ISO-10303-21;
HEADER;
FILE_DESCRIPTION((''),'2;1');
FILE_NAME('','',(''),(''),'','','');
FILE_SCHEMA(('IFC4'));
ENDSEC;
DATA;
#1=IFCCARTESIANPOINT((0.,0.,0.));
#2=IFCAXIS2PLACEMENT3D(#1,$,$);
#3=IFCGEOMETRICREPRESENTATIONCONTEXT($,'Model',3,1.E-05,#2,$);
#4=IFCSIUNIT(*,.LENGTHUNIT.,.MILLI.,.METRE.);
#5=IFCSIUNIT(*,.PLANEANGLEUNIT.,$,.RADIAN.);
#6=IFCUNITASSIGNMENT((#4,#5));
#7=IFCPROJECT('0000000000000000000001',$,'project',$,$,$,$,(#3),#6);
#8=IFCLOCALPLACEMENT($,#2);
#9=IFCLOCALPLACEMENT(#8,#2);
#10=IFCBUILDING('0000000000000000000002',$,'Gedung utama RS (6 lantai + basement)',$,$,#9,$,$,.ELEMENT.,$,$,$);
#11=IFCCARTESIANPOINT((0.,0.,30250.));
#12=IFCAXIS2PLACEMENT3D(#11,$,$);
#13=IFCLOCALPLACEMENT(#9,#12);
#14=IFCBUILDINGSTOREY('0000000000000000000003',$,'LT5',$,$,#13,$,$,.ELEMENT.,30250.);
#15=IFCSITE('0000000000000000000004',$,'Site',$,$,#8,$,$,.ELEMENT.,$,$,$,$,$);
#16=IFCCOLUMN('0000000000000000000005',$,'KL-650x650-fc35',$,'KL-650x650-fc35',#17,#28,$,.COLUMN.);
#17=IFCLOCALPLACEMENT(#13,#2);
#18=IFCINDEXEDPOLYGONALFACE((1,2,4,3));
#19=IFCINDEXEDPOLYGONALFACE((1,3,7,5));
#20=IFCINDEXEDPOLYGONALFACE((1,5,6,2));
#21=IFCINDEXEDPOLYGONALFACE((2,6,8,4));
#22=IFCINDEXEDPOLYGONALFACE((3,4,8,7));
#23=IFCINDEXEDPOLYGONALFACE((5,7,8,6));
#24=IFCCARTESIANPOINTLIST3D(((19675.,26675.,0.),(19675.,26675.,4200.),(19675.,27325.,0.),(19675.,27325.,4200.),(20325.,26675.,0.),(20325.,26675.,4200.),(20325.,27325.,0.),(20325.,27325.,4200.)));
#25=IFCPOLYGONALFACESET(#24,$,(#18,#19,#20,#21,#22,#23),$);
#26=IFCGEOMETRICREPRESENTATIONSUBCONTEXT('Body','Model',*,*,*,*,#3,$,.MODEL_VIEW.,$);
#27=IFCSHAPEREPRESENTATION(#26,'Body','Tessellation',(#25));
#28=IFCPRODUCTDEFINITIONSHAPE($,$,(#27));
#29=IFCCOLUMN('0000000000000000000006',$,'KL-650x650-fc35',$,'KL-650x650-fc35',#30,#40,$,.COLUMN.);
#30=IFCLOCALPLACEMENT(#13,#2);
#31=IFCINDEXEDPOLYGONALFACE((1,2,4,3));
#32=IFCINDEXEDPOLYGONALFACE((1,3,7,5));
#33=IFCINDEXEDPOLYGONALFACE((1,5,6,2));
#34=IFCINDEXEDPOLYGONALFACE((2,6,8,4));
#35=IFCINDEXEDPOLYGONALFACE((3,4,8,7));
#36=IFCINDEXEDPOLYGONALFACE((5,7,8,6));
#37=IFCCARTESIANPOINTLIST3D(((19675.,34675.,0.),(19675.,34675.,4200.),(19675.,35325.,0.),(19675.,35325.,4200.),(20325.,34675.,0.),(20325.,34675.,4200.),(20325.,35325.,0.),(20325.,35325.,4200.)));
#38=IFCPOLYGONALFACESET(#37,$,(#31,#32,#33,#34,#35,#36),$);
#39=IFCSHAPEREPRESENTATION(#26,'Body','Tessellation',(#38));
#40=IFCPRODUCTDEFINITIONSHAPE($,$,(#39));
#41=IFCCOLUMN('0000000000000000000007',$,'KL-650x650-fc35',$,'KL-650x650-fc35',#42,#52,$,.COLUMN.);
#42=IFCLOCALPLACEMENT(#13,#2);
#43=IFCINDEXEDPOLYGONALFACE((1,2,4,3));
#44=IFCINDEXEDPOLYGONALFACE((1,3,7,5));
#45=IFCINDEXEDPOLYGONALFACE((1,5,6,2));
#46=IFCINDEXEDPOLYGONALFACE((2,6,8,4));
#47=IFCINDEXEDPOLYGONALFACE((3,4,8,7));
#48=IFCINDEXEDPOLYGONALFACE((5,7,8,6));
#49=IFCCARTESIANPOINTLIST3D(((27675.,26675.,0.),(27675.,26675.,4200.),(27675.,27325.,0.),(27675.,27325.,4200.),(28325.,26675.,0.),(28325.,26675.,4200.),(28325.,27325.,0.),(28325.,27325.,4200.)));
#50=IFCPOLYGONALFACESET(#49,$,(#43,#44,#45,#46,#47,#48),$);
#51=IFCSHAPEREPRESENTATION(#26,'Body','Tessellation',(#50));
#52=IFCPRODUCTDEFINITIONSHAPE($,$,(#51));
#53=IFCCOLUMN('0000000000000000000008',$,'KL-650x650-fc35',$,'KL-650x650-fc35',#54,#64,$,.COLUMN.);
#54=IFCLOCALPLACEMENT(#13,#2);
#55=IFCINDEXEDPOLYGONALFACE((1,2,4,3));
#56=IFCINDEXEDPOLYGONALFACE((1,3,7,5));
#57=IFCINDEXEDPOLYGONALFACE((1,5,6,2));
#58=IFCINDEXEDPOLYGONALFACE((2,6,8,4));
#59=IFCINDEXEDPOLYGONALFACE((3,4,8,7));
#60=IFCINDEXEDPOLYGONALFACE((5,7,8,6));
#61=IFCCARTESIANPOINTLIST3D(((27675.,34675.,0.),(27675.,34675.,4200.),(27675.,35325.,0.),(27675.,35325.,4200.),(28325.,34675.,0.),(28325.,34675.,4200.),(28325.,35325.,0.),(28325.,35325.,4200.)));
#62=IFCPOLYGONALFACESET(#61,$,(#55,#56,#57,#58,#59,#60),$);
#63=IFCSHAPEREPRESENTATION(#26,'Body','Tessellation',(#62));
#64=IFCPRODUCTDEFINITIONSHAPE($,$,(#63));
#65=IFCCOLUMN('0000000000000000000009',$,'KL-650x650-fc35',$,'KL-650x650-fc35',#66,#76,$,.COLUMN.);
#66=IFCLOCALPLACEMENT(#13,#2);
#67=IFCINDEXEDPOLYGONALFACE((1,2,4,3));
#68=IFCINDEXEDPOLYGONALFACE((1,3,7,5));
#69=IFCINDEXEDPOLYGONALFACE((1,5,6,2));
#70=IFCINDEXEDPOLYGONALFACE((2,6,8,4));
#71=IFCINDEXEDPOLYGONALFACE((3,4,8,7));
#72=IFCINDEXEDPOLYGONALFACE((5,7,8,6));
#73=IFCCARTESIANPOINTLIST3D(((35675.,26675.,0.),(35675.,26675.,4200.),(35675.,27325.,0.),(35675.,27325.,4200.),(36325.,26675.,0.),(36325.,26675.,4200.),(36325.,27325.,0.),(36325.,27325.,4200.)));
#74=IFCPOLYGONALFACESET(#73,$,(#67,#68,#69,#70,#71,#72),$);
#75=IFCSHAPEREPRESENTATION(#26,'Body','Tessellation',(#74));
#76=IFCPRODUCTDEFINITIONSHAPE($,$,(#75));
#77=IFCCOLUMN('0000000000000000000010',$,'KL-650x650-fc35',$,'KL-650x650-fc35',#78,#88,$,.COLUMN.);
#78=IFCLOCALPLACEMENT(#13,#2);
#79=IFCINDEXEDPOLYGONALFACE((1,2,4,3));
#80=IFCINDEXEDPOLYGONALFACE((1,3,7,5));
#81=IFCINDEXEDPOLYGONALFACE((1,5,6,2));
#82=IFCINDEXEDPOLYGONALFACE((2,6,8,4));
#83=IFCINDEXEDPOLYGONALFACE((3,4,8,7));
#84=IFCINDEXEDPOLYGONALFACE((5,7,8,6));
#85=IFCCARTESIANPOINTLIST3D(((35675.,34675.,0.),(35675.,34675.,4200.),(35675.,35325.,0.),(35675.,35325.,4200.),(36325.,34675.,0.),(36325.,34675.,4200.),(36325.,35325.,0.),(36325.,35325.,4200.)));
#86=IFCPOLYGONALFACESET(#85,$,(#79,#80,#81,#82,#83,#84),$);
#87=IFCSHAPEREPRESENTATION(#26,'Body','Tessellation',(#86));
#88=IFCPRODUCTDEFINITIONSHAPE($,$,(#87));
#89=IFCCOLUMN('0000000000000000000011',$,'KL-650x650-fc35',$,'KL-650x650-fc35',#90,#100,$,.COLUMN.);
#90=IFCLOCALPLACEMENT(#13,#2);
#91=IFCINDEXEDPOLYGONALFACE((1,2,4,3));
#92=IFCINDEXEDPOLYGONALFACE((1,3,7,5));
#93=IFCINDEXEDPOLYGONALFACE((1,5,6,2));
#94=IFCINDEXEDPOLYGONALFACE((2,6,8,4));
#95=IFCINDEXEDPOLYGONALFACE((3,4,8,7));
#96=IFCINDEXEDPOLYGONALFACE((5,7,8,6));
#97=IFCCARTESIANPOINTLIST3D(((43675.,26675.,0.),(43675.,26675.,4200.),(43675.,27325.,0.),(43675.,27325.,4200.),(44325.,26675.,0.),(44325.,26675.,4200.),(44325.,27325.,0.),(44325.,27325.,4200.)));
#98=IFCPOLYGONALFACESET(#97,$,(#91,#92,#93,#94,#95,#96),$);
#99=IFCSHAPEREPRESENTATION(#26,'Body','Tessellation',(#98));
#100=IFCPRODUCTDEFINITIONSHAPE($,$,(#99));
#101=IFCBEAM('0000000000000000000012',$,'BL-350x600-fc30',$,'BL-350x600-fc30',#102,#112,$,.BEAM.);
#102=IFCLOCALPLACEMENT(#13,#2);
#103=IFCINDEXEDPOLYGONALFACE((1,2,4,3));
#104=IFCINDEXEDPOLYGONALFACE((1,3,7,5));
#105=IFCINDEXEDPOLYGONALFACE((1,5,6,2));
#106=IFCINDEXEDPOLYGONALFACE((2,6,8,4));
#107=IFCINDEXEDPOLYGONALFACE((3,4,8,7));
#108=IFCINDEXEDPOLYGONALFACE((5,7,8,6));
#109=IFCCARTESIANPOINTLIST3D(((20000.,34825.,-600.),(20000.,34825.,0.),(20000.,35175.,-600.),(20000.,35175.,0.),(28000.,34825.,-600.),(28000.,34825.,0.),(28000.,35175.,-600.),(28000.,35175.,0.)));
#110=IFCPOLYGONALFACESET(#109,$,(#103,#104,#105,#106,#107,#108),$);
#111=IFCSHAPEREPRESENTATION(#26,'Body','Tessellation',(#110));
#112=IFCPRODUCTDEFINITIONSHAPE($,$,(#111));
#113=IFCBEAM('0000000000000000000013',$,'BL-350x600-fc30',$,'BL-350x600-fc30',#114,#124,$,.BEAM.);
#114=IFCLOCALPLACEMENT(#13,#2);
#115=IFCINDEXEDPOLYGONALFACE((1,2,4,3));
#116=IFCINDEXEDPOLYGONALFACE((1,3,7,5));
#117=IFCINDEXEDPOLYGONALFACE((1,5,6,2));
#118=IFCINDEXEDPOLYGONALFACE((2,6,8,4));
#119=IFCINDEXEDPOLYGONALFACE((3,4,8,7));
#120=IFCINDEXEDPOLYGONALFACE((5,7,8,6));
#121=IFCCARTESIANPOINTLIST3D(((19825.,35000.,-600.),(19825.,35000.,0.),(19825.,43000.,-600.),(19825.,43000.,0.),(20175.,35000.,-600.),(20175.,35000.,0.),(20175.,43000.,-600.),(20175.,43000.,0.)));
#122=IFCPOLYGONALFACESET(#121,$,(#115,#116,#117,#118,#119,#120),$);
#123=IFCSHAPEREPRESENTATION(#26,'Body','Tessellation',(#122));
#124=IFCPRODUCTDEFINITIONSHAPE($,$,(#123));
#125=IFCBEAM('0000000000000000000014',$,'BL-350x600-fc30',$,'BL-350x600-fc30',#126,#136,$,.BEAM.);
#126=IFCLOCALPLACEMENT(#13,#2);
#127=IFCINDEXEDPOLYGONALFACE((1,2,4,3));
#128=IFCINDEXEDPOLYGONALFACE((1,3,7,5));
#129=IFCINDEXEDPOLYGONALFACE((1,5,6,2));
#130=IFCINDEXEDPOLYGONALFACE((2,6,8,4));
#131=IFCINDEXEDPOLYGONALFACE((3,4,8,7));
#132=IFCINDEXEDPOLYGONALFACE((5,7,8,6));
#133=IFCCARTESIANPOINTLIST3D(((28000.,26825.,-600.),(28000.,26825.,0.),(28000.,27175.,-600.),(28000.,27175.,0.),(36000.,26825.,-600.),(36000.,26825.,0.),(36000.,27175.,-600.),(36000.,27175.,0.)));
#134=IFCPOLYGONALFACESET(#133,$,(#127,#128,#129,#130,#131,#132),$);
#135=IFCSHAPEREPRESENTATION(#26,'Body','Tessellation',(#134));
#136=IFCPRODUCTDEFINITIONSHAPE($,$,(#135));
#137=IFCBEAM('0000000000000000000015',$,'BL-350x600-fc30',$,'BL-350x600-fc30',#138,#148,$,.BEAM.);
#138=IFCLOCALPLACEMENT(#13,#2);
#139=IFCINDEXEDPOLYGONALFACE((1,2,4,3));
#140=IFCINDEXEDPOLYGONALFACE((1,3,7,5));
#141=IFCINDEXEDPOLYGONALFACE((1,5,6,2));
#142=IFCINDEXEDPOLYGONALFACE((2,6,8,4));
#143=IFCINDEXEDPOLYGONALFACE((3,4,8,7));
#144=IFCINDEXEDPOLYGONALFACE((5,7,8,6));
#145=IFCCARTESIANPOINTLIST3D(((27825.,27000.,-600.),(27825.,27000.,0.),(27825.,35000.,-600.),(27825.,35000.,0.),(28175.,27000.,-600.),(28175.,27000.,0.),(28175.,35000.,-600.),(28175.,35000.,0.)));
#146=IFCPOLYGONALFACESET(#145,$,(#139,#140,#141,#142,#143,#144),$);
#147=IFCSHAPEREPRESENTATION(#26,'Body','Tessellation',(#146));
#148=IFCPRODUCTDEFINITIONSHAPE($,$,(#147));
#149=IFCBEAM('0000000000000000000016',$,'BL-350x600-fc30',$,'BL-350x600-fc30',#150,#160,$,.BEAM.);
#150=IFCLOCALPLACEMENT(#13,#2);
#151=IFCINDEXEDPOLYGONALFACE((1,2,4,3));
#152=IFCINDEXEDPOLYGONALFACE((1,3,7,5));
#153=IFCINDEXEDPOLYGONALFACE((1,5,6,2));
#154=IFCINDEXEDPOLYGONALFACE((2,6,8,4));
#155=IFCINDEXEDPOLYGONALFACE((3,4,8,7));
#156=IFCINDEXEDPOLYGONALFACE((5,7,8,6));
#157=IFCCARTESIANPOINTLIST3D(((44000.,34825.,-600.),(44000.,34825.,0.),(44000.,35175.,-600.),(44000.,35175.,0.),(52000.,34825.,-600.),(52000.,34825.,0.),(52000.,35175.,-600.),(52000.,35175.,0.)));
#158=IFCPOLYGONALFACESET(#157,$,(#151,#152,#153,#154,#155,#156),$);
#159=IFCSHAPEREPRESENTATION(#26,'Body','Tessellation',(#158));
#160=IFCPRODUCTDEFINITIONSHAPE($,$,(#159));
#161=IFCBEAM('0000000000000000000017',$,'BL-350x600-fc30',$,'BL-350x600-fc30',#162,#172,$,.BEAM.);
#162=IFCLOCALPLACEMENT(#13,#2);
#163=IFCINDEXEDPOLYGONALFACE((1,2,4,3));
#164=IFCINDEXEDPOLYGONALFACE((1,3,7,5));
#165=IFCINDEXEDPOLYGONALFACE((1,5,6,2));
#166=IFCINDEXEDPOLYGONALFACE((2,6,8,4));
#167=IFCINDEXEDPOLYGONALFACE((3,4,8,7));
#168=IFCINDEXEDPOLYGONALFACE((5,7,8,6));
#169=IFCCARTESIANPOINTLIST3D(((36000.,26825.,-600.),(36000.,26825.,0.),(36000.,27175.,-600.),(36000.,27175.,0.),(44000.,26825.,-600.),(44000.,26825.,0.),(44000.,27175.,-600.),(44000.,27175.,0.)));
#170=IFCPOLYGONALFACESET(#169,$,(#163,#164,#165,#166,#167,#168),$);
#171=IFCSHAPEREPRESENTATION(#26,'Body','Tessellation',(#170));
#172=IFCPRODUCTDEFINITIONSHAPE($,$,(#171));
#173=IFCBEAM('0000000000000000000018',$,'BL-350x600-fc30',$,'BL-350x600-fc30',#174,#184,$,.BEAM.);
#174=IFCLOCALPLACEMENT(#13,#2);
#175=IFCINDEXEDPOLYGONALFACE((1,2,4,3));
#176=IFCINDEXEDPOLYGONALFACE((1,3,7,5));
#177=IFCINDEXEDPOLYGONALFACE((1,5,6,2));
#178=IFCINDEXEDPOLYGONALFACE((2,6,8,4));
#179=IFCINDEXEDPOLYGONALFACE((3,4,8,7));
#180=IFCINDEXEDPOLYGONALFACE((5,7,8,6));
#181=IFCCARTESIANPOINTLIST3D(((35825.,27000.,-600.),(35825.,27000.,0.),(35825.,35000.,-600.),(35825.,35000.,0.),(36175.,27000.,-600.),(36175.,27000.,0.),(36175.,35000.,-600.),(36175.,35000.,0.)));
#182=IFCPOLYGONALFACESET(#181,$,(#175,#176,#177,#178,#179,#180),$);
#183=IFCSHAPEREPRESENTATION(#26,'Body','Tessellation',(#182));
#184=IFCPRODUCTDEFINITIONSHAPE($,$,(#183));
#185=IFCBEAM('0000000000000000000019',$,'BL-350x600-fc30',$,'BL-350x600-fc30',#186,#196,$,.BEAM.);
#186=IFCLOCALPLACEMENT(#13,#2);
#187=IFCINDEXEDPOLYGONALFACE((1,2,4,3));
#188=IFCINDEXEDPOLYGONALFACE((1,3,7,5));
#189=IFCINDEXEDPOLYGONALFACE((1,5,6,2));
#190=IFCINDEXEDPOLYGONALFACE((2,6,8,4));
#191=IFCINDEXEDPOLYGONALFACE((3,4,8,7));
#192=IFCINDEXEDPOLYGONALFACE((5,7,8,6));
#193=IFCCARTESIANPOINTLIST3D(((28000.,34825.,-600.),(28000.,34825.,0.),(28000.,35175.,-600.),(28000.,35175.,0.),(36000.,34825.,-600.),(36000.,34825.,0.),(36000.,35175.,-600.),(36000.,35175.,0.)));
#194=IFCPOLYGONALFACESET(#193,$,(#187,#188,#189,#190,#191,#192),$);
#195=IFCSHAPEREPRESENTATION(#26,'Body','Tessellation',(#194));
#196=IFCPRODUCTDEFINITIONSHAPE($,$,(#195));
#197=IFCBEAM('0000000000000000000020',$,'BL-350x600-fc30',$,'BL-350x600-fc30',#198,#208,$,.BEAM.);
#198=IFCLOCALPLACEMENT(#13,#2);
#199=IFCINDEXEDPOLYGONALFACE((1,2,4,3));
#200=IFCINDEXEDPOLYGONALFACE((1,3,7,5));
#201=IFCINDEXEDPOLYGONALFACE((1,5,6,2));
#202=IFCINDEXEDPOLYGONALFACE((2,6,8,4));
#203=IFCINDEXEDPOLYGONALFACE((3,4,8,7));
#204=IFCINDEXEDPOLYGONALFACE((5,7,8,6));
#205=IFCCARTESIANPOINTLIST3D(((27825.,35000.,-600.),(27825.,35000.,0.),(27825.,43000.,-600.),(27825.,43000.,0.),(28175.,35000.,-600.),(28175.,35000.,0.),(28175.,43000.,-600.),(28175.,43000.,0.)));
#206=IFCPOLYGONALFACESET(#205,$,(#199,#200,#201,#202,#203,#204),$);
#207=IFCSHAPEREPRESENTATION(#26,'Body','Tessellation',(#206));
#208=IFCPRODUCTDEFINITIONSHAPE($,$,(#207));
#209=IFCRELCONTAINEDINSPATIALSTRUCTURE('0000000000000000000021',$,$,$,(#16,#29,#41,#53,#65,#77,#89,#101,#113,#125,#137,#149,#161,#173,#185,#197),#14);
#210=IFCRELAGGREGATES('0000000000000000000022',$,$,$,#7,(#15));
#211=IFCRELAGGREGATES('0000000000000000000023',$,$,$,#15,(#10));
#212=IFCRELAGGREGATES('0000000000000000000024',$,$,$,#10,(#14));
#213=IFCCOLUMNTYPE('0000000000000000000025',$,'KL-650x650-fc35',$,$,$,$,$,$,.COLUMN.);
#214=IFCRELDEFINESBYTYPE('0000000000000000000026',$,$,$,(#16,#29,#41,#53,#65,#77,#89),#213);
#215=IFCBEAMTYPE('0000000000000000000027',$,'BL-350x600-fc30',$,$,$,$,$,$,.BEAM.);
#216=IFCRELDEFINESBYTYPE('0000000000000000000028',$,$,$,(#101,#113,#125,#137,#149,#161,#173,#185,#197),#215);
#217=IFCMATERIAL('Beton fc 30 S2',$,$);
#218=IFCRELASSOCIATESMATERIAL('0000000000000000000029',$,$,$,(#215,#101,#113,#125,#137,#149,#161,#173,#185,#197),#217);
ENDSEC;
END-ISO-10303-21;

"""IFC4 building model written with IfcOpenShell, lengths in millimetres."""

from ifc_helpers import new_model, si_unit, frame, origin, origin_2d, place, context, subcontext, project, spatial, rectangle, extrude, material, material_profile, profile_set, profile_usage, type_object, element, save


model = new_model("IFC4")

# Units and contexts
model_context = context("Model", 3, precision=1e-05, world=origin())
body_context = subcontext(model_context, "Body", "Model", "MODEL_VIEW")
ifc_project = project(units=[si_unit("LENGTHUNIT", "METRE", prefix="MILLI"), si_unit("PLANEANGLEUNIT", "RADIAN")], contexts=[model_context])

# Site, building, storey
site_placement = place(None, origin())
site = spatial("IfcSite", under=ifc_project, at=site_placement, Name="Site", CompositionType="ELEMENT")
building_placement = place(site_placement, origin())
building = spatial("IfcBuilding", under=site, at=building_placement, Name="Gedung utama RS (6 lantai + basement)", CompositionType="ELEMENT")
storey_placement = place(building_placement, frame((0.0, 0.0, 30250.0)))
storey = spatial("IfcBuildingStorey", under=building, at=storey_placement, Name="LT5", CompositionType="ELEMENT", Elevation=30250.0)

# Columns
ifc_material_profile_1 = material_profile(None, rectangle(XDim=650.0, YDim=650.0, at=origin_2d()), Name="KL-650x650-fc35")
ifc_profile_set_1 = profile_set([ifc_material_profile_1], Name="KL-650x650-fc35")
ifc_profile_usage_1 = profile_usage(ifc_profile_set_1, cardinal=5)
column_type = type_object("IfcColumnType", Name="KL-650x650-fc35", PredefinedType="COLUMN", material=ifc_profile_set_1)
for number, where, z_axis, x_axis, name in (
    (1, (20000.0, 27000.0, 0.0), (0.0, 0.0, 1.0), (1.0, 0.0, 0.0), "KL-650x650-fc35"),
    (2, (20000.0, 35000.0, 0.0), (0.0, 0.0, 1.0), (1.0, 0.0, 0.0), "KL-650x650-fc35"),
    (3, (28000.0, 27000.0, 0.0), (0.0, 0.0, 1.0), (1.0, 0.0, 0.0), "KL-650x650-fc35"),
    (4, (28000.0, 35000.0, 0.0), (0.0, 0.0, 1.0), (1.0, 0.0, 0.0), "KL-650x650-fc35"),
    (5, (36000.0, 27000.0, 0.0), (0.0, 0.0, 1.0), (1.0, 0.0, 0.0), "KL-650x650-fc35"),
    (6, (36000.0, 35000.0, 0.0), (0.0, 0.0, 1.0), (1.0, 0.0, 0.0), "KL-650x650-fc35"),
    (7, (44000.0, 27000.0, 0.0), (0.0, 0.0, 1.0), (1.0, 0.0, 0.0), "KL-650x650-fc35"),
):
    element("IfcColumn", number, at=place(storey_placement, frame(where, z_axis=z_axis, x_axis=x_axis)), inside=storey, type_object=column_type, material=ifc_profile_usage_1, Name=name, ObjectType="KL-650x650-fc35", PredefinedType="COLUMN", context=body_context, shape_type="SweptSolid", body=[
        extrude(rectangle(XDim=650.0, YDim=650.0, at=origin_2d()), origin(), (0.0, 0.0, 1.0), 4200.0),
    ])

# Beams
ifc_material = material(Name="Beton fc 30 S2")
ifc_material_profile_2 = material_profile(ifc_material, rectangle(XDim=350.0, YDim=600.0, at=origin_2d()), Name="BL-350x600-fc30")
ifc_profile_set_2 = profile_set([ifc_material_profile_2], Name="BL-350x600-fc30")
ifc_profile_usage_2 = profile_usage(ifc_profile_set_2, cardinal=8)
beam_type = type_object("IfcBeamType", Name="BL-350x600-fc30", PredefinedType="BEAM", material=ifc_profile_set_2)
beam_1_placement = place(storey_placement, frame((20000.0, 35000.0, -300.0)))
element("IfcBeam", 8, at=beam_1_placement, inside=storey, type_object=beam_type, material=ifc_profile_usage_2, Name="BL-350x600-fc30", ObjectType="BL-350x600-fc30", PredefinedType="BEAM", context=body_context, shape_type="SweptSolid", body=[
    extrude(rectangle(XDim=350.0, YDim=600.0, at=origin_2d()), frame((0.0, 0.0, 0.0), z_axis=(1.0, 0.0, 0.0), x_axis=(0.0, 1.0, 0.0)), (0.0, 0.0, 1.0), 8000.0),
])
beam_2_placement = place(storey_placement, frame((20000.0, 35000.0, -300.0)))
element("IfcBeam", 9, at=beam_2_placement, inside=storey, type_object=beam_type, material=ifc_profile_usage_2, Name="BL-350x600-fc30", ObjectType="BL-350x600-fc30", PredefinedType="BEAM", context=body_context, shape_type="SweptSolid", body=[
    extrude(rectangle(XDim=350.0, YDim=600.0, at=origin_2d()), frame((0.0, 0.0, 0.0), z_axis=(0.0, 1.0, 0.0), x_axis=(-1.0, 0.0, 0.0)), (0.0, 0.0, 1.0), 8000.0),
])
beam_3_placement = place(storey_placement, frame((28000.0, 27000.0, -300.0)))
element("IfcBeam", 10, at=beam_3_placement, inside=storey, type_object=beam_type, material=ifc_profile_usage_2, Name="BL-350x600-fc30", ObjectType="BL-350x600-fc30", PredefinedType="BEAM", context=body_context, shape_type="SweptSolid", body=[
    extrude(rectangle(XDim=350.0, YDim=600.0, at=origin_2d()), frame((0.0, 0.0, 0.0), z_axis=(1.0, 0.0, 0.0), x_axis=(0.0, 1.0, 0.0)), (0.0, 0.0, 1.0), 8000.0),
])
beam_4_placement = place(storey_placement, frame((28000.0, 27000.0, -300.0)))
element("IfcBeam", 11, at=beam_4_placement, inside=storey, type_object=beam_type, material=ifc_profile_usage_2, Name="BL-350x600-fc30", ObjectType="BL-350x600-fc30", PredefinedType="BEAM", context=body_context, shape_type="SweptSolid", body=[
    extrude(rectangle(XDim=350.0, YDim=600.0, at=origin_2d()), frame((0.0, 0.0, 0.0), z_axis=(0.0, 1.0, 0.0), x_axis=(-1.0, 0.0, 0.0)), (0.0, 0.0, 1.0), 8000.0),
])
for number, where, name in (
    (12, (44000.0, 35000.0, -300.0), "BL-350x600-fc30"),
    (13, (36000.0, 27000.0, -300.0), "BL-350x600-fc30"),
):
    element("IfcBeam", number, at=place(storey_placement, frame(where)), inside=storey, type_object=beam_type, material=ifc_profile_usage_2, Name=name, ObjectType="BL-350x600-fc30", PredefinedType="BEAM", context=body_context, shape_type="SweptSolid", body=[
        extrude(rectangle(XDim=350.0, YDim=600.0, at=origin_2d()), frame((0.0, 0.0, 0.0), z_axis=(1.0, 0.0, 0.0), x_axis=(0.0, 1.0, 0.0)), (0.0, 0.0, 1.0), 8000.0),
    ])
beam_5_placement = place(storey_placement, frame((36000.0, 27000.0, -300.0)))
element("IfcBeam", 14, at=beam_5_placement, inside=storey, type_object=beam_type, material=ifc_profile_usage_2, Name="BL-350x600-fc30", ObjectType="BL-350x600-fc30", PredefinedType="BEAM", context=body_context, shape_type="SweptSolid", body=[
    extrude(rectangle(XDim=350.0, YDim=600.0, at=origin_2d()), frame((0.0, 0.0, 0.0), z_axis=(0.0, 1.0, 0.0), x_axis=(-1.0, 0.0, 0.0)), (0.0, 0.0, 1.0), 8000.0),
])
beam_6_placement = place(storey_placement, frame((28000.0, 35000.0, -300.0)))
element("IfcBeam", 15, at=beam_6_placement, inside=storey, type_object=beam_type, material=ifc_profile_usage_2, Name="BL-350x600-fc30", ObjectType="BL-350x600-fc30", PredefinedType="BEAM", context=body_context, shape_type="SweptSolid", body=[
    extrude(rectangle(XDim=350.0, YDim=600.0, at=origin_2d()), frame((0.0, 0.0, 0.0), z_axis=(1.0, 0.0, 0.0), x_axis=(0.0, 1.0, 0.0)), (0.0, 0.0, 1.0), 8000.0),
])
beam_7_placement = place(storey_placement, frame((28000.0, 35000.0, -300.0)))
element("IfcBeam", 16, at=beam_7_placement, inside=storey, type_object=beam_type, material=ifc_profile_usage_2, Name="BL-350x600-fc30", ObjectType="BL-350x600-fc30", PredefinedType="BEAM", context=body_context, shape_type="SweptSolid", body=[
    extrude(rectangle(XDim=350.0, YDim=600.0, at=origin_2d()), frame((0.0, 0.0, 0.0), z_axis=(0.0, 1.0, 0.0), x_axis=(-1.0, 0.0, 0.0)), (0.0, 0.0, 1.0), 8000.0),
])

save(model, "model.ifc")
